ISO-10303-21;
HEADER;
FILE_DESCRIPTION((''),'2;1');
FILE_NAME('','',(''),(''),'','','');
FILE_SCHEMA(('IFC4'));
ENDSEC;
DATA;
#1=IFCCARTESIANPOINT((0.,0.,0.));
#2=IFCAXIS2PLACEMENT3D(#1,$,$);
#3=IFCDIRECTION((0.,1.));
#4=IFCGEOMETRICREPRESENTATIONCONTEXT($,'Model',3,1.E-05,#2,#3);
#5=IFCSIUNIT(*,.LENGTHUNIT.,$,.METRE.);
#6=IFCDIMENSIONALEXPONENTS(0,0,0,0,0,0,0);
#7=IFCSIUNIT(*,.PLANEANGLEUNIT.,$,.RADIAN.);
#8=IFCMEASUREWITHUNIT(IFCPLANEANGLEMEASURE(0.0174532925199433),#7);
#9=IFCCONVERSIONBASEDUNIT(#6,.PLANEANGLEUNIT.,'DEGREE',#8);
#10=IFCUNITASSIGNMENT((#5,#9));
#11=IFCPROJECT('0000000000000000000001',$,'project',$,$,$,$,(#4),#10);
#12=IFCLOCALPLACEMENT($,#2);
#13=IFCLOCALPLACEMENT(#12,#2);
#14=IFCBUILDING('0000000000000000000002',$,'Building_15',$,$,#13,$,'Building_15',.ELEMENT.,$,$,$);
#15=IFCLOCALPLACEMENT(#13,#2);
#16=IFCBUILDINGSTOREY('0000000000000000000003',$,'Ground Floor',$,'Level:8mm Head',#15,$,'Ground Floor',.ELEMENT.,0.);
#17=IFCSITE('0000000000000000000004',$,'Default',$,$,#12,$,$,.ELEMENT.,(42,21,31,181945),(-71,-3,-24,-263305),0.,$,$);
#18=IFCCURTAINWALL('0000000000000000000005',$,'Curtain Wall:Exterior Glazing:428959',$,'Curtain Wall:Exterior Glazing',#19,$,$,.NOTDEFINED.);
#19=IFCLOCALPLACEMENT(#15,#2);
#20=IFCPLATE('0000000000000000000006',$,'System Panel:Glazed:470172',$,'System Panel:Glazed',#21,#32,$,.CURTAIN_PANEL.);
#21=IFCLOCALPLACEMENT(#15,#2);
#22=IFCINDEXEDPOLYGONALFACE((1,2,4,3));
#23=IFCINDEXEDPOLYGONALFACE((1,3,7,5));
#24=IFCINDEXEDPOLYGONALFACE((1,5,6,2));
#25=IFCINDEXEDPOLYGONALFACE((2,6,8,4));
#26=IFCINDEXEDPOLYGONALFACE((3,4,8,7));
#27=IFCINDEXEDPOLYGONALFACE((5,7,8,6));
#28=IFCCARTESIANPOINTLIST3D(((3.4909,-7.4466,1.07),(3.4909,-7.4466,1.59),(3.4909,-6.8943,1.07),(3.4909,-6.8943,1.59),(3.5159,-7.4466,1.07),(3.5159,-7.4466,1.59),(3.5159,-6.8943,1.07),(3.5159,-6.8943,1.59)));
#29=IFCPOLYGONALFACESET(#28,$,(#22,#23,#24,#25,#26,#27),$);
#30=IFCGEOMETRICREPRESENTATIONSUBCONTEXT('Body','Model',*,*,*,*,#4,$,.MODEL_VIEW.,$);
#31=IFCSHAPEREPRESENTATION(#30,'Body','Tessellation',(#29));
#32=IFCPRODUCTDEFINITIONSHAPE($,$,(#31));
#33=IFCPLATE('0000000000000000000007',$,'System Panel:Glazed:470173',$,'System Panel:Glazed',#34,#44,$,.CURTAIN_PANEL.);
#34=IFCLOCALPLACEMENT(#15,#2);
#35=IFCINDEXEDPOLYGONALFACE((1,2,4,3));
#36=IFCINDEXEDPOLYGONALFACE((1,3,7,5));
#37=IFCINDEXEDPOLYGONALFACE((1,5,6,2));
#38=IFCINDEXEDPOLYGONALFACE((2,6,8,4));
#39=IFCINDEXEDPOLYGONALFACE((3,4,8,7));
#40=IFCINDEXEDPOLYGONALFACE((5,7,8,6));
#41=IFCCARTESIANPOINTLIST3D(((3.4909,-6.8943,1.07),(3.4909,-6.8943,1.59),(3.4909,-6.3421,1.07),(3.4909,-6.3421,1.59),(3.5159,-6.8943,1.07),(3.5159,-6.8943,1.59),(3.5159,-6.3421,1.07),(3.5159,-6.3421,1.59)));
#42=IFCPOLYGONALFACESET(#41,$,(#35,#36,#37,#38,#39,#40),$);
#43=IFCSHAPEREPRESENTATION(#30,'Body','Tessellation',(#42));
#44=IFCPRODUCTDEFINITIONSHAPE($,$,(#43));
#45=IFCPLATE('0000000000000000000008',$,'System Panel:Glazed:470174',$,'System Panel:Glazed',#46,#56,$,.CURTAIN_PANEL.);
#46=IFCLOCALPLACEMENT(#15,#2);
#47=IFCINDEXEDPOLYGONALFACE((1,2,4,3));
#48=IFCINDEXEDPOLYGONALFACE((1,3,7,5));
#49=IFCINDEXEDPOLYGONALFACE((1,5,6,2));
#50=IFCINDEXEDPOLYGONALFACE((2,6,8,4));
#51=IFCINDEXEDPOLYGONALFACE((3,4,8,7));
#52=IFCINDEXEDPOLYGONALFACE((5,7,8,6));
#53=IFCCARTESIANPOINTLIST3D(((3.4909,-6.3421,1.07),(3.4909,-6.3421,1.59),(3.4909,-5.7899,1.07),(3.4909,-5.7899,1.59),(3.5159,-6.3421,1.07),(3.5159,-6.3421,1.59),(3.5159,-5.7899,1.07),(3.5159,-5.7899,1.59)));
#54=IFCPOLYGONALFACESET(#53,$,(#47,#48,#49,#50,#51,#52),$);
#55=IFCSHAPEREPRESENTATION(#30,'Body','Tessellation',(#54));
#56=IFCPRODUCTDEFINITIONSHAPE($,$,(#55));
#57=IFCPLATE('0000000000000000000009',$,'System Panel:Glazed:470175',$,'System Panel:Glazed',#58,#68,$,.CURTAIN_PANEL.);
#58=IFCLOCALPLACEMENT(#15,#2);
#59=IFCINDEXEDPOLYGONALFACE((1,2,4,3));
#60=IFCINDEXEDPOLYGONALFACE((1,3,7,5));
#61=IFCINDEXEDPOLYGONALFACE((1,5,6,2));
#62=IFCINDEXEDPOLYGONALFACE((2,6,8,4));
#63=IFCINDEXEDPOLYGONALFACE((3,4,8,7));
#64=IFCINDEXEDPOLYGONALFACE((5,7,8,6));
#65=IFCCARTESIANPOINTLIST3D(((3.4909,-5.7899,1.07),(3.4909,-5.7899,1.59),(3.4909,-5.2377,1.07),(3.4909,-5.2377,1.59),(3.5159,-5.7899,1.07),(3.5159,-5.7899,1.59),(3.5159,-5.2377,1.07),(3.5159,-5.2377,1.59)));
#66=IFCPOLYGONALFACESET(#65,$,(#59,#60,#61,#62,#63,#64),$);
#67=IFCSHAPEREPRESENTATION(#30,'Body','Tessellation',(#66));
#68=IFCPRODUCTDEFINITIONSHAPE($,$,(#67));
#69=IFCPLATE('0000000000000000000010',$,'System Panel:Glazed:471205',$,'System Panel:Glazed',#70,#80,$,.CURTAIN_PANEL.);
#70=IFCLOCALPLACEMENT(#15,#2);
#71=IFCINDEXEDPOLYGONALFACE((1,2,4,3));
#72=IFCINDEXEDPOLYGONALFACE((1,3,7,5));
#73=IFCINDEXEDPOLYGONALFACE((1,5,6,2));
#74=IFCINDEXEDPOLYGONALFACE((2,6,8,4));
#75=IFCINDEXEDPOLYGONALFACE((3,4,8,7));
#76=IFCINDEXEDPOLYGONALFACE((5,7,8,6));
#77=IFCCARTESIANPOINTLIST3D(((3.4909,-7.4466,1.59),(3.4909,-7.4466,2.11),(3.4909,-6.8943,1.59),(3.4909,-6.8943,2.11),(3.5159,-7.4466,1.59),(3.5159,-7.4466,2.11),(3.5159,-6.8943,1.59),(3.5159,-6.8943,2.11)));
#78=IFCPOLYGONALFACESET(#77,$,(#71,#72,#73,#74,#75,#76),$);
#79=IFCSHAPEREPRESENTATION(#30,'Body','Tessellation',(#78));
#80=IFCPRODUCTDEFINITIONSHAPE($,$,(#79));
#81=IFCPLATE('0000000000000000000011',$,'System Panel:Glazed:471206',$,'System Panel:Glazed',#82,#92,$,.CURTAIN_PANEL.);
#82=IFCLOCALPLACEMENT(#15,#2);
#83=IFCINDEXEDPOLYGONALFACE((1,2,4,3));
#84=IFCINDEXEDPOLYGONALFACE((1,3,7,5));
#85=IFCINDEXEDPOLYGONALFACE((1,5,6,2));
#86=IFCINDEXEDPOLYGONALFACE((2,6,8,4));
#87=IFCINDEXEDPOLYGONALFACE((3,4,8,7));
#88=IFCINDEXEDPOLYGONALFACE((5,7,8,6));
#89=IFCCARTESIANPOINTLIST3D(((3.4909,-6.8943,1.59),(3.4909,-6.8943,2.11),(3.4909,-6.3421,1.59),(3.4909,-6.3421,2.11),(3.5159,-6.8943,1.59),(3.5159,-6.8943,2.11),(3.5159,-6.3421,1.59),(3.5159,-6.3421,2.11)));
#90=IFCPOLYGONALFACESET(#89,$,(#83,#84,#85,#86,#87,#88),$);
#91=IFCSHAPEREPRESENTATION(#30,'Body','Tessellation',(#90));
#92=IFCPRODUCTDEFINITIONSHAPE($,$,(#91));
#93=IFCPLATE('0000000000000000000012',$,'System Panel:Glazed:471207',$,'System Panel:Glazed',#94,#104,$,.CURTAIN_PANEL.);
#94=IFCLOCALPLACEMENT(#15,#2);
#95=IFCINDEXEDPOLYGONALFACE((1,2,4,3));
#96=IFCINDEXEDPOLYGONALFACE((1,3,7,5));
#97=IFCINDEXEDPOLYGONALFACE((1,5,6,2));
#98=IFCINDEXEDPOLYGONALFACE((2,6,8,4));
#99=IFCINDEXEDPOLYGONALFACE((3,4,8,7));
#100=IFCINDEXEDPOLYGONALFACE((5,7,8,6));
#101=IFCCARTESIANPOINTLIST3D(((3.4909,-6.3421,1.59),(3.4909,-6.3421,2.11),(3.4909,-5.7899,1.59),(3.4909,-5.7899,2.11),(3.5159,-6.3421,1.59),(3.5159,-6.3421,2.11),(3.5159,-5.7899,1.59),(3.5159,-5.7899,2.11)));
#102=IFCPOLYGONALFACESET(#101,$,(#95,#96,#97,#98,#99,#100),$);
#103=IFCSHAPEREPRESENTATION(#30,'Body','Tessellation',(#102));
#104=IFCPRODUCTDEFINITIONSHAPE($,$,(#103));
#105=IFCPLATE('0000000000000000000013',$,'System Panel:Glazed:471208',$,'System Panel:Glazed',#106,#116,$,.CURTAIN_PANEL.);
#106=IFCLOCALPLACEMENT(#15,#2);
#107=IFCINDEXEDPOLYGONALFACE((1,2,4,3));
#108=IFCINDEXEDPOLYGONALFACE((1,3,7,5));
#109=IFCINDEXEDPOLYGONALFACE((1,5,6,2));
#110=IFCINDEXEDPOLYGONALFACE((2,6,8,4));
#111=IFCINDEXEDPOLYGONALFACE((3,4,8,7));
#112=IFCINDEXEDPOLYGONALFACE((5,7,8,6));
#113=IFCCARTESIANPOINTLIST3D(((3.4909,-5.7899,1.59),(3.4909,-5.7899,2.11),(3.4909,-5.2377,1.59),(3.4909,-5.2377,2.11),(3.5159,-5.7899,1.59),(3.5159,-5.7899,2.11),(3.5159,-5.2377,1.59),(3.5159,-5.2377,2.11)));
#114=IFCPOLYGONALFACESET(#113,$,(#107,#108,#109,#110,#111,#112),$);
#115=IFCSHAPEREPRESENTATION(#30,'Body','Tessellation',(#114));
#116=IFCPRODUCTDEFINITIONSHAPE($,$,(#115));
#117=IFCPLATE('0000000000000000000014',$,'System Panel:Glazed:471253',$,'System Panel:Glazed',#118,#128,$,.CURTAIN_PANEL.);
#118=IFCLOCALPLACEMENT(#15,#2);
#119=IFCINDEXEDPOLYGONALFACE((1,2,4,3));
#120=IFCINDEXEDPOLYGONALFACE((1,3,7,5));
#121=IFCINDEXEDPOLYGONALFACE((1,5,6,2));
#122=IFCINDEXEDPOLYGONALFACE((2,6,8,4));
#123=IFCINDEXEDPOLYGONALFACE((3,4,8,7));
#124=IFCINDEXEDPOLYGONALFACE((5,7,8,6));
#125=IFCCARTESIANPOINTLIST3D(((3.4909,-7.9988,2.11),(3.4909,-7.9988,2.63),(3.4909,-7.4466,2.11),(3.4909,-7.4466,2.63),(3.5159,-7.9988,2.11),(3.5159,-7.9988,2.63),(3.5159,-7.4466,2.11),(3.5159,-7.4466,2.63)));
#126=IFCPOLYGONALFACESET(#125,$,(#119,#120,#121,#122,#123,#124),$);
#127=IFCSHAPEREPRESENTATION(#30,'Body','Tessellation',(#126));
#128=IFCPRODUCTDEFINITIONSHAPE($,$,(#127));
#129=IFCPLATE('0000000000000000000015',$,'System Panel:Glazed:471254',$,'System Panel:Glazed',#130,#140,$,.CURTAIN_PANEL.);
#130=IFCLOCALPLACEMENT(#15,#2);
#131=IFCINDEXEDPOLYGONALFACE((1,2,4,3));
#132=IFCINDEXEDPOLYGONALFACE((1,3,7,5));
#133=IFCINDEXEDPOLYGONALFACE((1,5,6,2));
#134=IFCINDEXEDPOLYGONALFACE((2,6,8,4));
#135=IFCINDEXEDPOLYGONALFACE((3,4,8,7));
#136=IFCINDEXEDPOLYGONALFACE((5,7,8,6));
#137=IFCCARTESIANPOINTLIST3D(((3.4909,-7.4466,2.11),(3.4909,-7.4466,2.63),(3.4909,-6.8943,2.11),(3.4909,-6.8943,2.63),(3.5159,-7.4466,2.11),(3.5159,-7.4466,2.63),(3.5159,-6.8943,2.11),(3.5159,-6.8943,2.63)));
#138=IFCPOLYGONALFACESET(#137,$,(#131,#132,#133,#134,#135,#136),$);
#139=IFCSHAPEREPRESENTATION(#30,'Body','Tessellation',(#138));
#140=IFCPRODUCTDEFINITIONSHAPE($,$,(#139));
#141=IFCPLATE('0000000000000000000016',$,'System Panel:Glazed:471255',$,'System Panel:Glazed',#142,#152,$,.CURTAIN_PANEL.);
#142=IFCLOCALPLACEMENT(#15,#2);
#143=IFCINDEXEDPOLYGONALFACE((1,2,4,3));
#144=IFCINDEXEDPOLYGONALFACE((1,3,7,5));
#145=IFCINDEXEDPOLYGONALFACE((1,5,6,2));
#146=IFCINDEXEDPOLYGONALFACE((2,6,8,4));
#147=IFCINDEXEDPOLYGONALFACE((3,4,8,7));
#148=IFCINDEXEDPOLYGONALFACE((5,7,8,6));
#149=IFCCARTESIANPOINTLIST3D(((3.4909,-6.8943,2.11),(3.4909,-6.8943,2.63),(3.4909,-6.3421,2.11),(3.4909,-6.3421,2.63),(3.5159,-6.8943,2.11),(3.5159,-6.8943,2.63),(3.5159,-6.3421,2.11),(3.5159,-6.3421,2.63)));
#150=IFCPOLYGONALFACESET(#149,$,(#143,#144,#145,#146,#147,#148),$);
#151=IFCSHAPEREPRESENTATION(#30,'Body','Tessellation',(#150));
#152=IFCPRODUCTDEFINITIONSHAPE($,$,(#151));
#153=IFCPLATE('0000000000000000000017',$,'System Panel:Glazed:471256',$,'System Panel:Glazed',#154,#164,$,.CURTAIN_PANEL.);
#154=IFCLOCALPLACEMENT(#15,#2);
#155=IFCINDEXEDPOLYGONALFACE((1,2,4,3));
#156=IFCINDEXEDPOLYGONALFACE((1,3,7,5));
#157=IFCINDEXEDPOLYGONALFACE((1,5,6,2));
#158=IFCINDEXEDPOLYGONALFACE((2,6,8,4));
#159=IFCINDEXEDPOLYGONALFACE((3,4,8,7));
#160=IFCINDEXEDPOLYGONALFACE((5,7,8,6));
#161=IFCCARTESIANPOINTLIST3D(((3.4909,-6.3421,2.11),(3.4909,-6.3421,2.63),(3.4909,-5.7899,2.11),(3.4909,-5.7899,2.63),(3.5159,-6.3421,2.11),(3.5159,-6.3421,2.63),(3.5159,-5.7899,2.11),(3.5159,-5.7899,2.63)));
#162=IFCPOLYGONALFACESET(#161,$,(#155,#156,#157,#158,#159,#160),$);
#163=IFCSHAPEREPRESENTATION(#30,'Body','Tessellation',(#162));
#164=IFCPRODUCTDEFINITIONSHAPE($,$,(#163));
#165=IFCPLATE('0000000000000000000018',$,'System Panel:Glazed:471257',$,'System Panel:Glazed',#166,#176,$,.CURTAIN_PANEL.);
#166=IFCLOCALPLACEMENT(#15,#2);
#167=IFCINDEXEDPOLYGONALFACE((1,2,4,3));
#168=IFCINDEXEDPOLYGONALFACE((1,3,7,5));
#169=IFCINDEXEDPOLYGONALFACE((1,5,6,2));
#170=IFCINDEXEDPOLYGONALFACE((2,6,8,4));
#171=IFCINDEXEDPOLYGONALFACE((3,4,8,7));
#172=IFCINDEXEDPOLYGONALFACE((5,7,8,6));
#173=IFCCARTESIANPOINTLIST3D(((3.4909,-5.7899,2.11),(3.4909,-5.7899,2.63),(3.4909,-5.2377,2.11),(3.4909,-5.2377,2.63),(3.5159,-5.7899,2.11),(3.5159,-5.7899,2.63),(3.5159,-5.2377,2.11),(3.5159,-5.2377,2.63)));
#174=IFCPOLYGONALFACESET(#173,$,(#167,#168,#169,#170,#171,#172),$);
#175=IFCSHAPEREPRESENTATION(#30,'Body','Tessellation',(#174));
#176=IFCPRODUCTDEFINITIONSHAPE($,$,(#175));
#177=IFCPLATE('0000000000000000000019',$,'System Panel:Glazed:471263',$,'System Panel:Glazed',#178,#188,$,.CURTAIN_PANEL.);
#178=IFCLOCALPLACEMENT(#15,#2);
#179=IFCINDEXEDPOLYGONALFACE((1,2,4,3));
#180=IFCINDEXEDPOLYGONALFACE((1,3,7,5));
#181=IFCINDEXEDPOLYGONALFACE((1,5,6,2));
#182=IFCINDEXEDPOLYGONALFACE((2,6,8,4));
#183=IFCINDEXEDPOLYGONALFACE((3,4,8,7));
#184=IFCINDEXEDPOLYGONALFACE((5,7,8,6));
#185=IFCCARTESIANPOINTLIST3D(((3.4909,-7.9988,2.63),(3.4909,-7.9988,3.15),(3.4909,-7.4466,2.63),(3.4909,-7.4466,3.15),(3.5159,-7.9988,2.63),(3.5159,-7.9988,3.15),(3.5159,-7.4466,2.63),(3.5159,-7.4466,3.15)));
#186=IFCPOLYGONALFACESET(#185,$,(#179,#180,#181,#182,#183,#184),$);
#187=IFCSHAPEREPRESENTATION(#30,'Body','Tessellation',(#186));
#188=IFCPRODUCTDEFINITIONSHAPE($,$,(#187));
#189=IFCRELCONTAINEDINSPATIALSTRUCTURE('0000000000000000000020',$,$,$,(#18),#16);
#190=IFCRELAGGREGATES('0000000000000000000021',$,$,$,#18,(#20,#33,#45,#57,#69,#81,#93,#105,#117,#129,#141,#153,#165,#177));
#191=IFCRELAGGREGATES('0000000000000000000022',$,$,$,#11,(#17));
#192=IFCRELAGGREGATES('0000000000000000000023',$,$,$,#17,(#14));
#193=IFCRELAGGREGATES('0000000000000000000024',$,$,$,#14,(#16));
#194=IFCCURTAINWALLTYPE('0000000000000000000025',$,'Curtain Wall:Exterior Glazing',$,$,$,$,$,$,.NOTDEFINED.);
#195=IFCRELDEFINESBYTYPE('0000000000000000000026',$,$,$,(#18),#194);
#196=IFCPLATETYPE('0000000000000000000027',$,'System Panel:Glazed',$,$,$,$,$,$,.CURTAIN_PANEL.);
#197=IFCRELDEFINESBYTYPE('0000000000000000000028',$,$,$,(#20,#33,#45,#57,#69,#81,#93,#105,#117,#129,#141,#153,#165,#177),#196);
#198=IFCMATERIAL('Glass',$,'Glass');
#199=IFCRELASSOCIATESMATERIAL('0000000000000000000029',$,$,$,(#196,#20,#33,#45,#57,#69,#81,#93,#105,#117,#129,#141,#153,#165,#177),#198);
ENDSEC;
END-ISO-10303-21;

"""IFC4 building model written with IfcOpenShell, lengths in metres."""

from ifc_helpers import new_model, entity, si_unit, converted_unit, direction, frame, origin, place, context, subcontext, project, spatial, indexed_curve, outline, extrude, source, transform, mapped, material, type_object, type_shapes, element, aggregate, save


model = new_model("IFC4")

# Units and contexts
model_context = context("Model", 3, precision=1e-05, world=origin(), true_north=direction((0.0, 1.0)))
body_context = subcontext(model_context, "Body", "Model", "MODEL_VIEW")
ifc_project = project(units=[si_unit("LENGTHUNIT", "METRE"), converted_unit("PLANEANGLEUNIT", "DEGREE", entity("IfcPlaneAngleMeasure", 0.0174532925199433), si_unit("PLANEANGLEUNIT", "RADIAN"), dimensions=[0, 0, 0, 0, 0, 0, 0])], contexts=[model_context])

# Site, building, storey
site_placement = place(None, origin())
site = spatial("IfcSite", under=ifc_project, at=site_placement, Name="Default", CompositionType="ELEMENT", RefLatitude=(42, 21, 31, 181945), RefLongitude=(-71, -3, -24, -263305), RefElevation=0.0)
building_placement = place(site_placement, origin())
building = spatial("IfcBuilding", under=site, at=building_placement, Name="Building_15", LongName="Building_15", CompositionType="ELEMENT")
storey_placement = place(building_placement, origin())
storey = spatial("IfcBuildingStorey", under=building, at=storey_placement, Name="Ground Floor", ObjectType="Level:8mm Head", LongName="Ground Floor", CompositionType="ELEMENT", Elevation=0.0)

# Curtain wall, plates
curtain_wall_type = type_object("IfcCurtainWallType", Name="Curtain Wall:Exterior Glazing", PredefinedType="NOTDEFINED")
curtain_wall_placement = place(storey_placement, origin())
curtain_wall = element("IfcCurtainWall", 1, at=curtain_wall_placement, inside=storey, type_object=curtain_wall_type, Name="Curtain Wall:Exterior Glazing:428959", ObjectType="Curtain Wall:Exterior Glazing", PredefinedType="NOTDEFINED")
ifc_material_1 = material(Name="Glass", Category="Glass")
plate_type_1 = type_object("IfcPlateType", Name="System Panel:Glazed", PredefinedType="CURTAIN_PANEL", material=ifc_material_1)
shared_shape_1 = source(origin(), body_context, "Body", "SweptSolid", [
    extrude(outline(indexed_curve([(-0.0125, -0.2761), (0.0125, -0.2761), (0.0125, 0.2761), (-0.0125, 0.2761), (-0.0125, -0.2761)], self_intersect=False)), frame((0.0, 0.037, 0.0), z_axis=(0.0, 0.0, 1.0), x_axis=(0.0, 1.0, 0.0)), (0.0, 0.0, 1.0), 0.52),
])
type_shapes(plate_type_1, [shared_shape_1])
plate_1_placement = place(curtain_wall_placement, frame((3.5404, -7.1705, 1.07), z_axis=(0.0, 0.0, 1.0), x_axis=(0.0, 1.0, 0.0)))
plate_1 = element("IfcPlate", 2, at=plate_1_placement, type_object=plate_type_1, material=ifc_material_1, Name="System Panel:Glazed:470172", ObjectType="System Panel:Glazed", PredefinedType="CURTAIN_PANEL", context=body_context, shape_type="MappedRepresentation", body=[
    mapped(shared_shape_1, transform((0.0, 0.0, 0.0), scale=1.0)),
])
plate_2_placement = place(curtain_wall_placement, frame((3.5404, -6.6182, 1.07), z_axis=(0.0, 0.0, 1.0), x_axis=(0.0, 1.0, 0.0)))
plate_2 = element("IfcPlate", 3, at=plate_2_placement, type_object=plate_type_1, material=ifc_material_1, Name="System Panel:Glazed:470173", ObjectType="System Panel:Glazed", PredefinedType="CURTAIN_PANEL", context=body_context, shape_type="MappedRepresentation", body=[
    mapped(shared_shape_1, transform((0.0, 0.0, 0.0), scale=1.0)),
])
plate_3_placement = place(curtain_wall_placement, frame((3.5404, -6.066, 1.07), z_axis=(0.0, 0.0, 1.0), x_axis=(0.0, 1.0, 0.0)))
plate_3 = element("IfcPlate", 4, at=plate_3_placement, type_object=plate_type_1, material=ifc_material_1, Name="System Panel:Glazed:470174", ObjectType="System Panel:Glazed", PredefinedType="CURTAIN_PANEL", context=body_context, shape_type="MappedRepresentation", body=[
    mapped(shared_shape_1, transform((0.0, 0.0, 0.0), scale=1.0)),
])
plate_4_placement = place(curtain_wall_placement, frame((3.5404, -5.5138, 1.07), z_axis=(0.0, 0.0, 1.0), x_axis=(0.0, 1.0, 0.0)))
plate_4 = element("IfcPlate", 5, at=plate_4_placement, type_object=plate_type_1, material=ifc_material_1, Name="System Panel:Glazed:470175", ObjectType="System Panel:Glazed", PredefinedType="CURTAIN_PANEL", context=body_context, shape_type="MappedRepresentation", body=[
    mapped(shared_shape_1, transform((0.0, 0.0, 0.0), scale=1.0)),
])
plate_5_placement = place(curtain_wall_placement, frame((3.5404, -7.1705, 1.59), z_axis=(0.0, 0.0, 1.0), x_axis=(0.0, 1.0, 0.0)))
plate_5 = element("IfcPlate", 6, at=plate_5_placement, type_object=plate_type_1, material=ifc_material_1, Name="System Panel:Glazed:471205", ObjectType="System Panel:Glazed", PredefinedType="CURTAIN_PANEL", context=body_context, shape_type="MappedRepresentation", body=[
    mapped(shared_shape_1, transform((0.0, 0.0, 0.0), scale=1.0)),
])
plate_6_placement = place(curtain_wall_placement, frame((3.5404, -6.6182, 1.59), z_axis=(0.0, 0.0, 1.0), x_axis=(0.0, 1.0, 0.0)))
plate_6 = element("IfcPlate", 7, at=plate_6_placement, type_object=plate_type_1, material=ifc_material_1, Name="System Panel:Glazed:471206", ObjectType="System Panel:Glazed", PredefinedType="CURTAIN_PANEL", context=body_context, shape_type="MappedRepresentation", body=[
    mapped(shared_shape_1, transform((0.0, 0.0, 0.0), scale=1.0)),
])
plate_7_placement = place(curtain_wall_placement, frame((3.5404, -6.066, 1.59), z_axis=(0.0, 0.0, 1.0), x_axis=(0.0, 1.0, 0.0)))
plate_7 = element("IfcPlate", 8, at=plate_7_placement, type_object=plate_type_1, material=ifc_material_1, Name="System Panel:Glazed:471207", ObjectType="System Panel:Glazed", PredefinedType="CURTAIN_PANEL", context=body_context, shape_type="MappedRepresentation", body=[
    mapped(shared_shape_1, transform((0.0, 0.0, 0.0), scale=1.0)),
])
plate_8_placement = place(curtain_wall_placement, frame((3.5404, -5.5138, 1.59), z_axis=(0.0, 0.0, 1.0), x_axis=(0.0, 1.0, 0.0)))
plate_8 = element("IfcPlate", 9, at=plate_8_placement, type_object=plate_type_1, material=ifc_material_1, Name="System Panel:Glazed:471208", ObjectType="System Panel:Glazed", PredefinedType="CURTAIN_PANEL", context=body_context, shape_type="MappedRepresentation", body=[
    mapped(shared_shape_1, transform((0.0, 0.0, 0.0), scale=1.0)),
])
plate_9_placement = place(curtain_wall_placement, frame((3.5404, -7.7227, 2.11), z_axis=(0.0, 0.0, 1.0), x_axis=(0.0, 1.0, 0.0)))
plate_9 = element("IfcPlate", 10, at=plate_9_placement, type_object=plate_type_1, material=ifc_material_1, Name="System Panel:Glazed:471253", ObjectType="System Panel:Glazed", PredefinedType="CURTAIN_PANEL", context=body_context, shape_type="MappedRepresentation", body=[
    mapped(shared_shape_1, transform((0.0, 0.0, 0.0), scale=1.0)),
])
plate_10_placement = place(curtain_wall_placement, frame((3.5404, -7.1705, 2.11), z_axis=(0.0, 0.0, 1.0), x_axis=(0.0, 1.0, 0.0)))
plate_10 = element("IfcPlate", 11, at=plate_10_placement, type_object=plate_type_1, material=ifc_material_1, Name="System Panel:Glazed:471254", ObjectType="System Panel:Glazed", PredefinedType="CURTAIN_PANEL", context=body_context, shape_type="MappedRepresentation", body=[
    mapped(shared_shape_1, transform((0.0, 0.0, 0.0), scale=1.0)),
])
plate_11_placement = place(curtain_wall_placement, frame((3.5404, -6.6182, 2.11), z_axis=(0.0, 0.0, 1.0), x_axis=(0.0, 1.0, 0.0)))
plate_11 = element("IfcPlate", 12, at=plate_11_placement, type_object=plate_type_1, material=ifc_material_1, Name="System Panel:Glazed:471255", ObjectType="System Panel:Glazed", PredefinedType="CURTAIN_PANEL", context=body_context, shape_type="MappedRepresentation", body=[
    mapped(shared_shape_1, transform((0.0, 0.0, 0.0), scale=1.0)),
])
plate_12_placement = place(curtain_wall_placement, frame((3.5404, -6.066, 2.11), z_axis=(0.0, 0.0, 1.0), x_axis=(0.0, 1.0, 0.0)))
plate_12 = element("IfcPlate", 13, at=plate_12_placement, type_object=plate_type_1, material=ifc_material_1, Name="System Panel:Glazed:471256", ObjectType="System Panel:Glazed", PredefinedType="CURTAIN_PANEL", context=body_context, shape_type="MappedRepresentation", body=[
    mapped(shared_shape_1, transform((0.0, 0.0, 0.0), scale=1.0)),
])
plate_13_placement = place(curtain_wall_placement, frame((3.5404, -5.5138, 2.11), z_axis=(0.0, 0.0, 1.0), x_axis=(0.0, 1.0, 0.0)))
plate_13 = element("IfcPlate", 14, at=plate_13_placement, type_object=plate_type_1, material=ifc_material_1, Name="System Panel:Glazed:471257", ObjectType="System Panel:Glazed", PredefinedType="CURTAIN_PANEL", context=body_context, shape_type="MappedRepresentation", body=[
    mapped(shared_shape_1, transform((0.0, 0.0, 0.0), scale=1.0)),
])
plate_14_placement = place(curtain_wall_placement, frame((3.5404, -7.7227, 2.63), z_axis=(0.0, 0.0, 1.0), x_axis=(0.0, 1.0, 0.0)))
plate_14 = element("IfcPlate", 15, at=plate_14_placement, type_object=plate_type_1, material=ifc_material_1, Name="System Panel:Glazed:471263", ObjectType="System Panel:Glazed", PredefinedType="CURTAIN_PANEL", context=body_context, shape_type="MappedRepresentation", body=[
    mapped(shared_shape_1, transform((0.0, 0.0, 0.0), scale=1.0)),
])
aggregate(curtain_wall, [plate_1, plate_2, plate_3, plate_4, plate_5, plate_6, plate_7, plate_8, plate_9, plate_10, plate_11, plate_12, plate_13, plate_14])

save(model, "model.ifc")
